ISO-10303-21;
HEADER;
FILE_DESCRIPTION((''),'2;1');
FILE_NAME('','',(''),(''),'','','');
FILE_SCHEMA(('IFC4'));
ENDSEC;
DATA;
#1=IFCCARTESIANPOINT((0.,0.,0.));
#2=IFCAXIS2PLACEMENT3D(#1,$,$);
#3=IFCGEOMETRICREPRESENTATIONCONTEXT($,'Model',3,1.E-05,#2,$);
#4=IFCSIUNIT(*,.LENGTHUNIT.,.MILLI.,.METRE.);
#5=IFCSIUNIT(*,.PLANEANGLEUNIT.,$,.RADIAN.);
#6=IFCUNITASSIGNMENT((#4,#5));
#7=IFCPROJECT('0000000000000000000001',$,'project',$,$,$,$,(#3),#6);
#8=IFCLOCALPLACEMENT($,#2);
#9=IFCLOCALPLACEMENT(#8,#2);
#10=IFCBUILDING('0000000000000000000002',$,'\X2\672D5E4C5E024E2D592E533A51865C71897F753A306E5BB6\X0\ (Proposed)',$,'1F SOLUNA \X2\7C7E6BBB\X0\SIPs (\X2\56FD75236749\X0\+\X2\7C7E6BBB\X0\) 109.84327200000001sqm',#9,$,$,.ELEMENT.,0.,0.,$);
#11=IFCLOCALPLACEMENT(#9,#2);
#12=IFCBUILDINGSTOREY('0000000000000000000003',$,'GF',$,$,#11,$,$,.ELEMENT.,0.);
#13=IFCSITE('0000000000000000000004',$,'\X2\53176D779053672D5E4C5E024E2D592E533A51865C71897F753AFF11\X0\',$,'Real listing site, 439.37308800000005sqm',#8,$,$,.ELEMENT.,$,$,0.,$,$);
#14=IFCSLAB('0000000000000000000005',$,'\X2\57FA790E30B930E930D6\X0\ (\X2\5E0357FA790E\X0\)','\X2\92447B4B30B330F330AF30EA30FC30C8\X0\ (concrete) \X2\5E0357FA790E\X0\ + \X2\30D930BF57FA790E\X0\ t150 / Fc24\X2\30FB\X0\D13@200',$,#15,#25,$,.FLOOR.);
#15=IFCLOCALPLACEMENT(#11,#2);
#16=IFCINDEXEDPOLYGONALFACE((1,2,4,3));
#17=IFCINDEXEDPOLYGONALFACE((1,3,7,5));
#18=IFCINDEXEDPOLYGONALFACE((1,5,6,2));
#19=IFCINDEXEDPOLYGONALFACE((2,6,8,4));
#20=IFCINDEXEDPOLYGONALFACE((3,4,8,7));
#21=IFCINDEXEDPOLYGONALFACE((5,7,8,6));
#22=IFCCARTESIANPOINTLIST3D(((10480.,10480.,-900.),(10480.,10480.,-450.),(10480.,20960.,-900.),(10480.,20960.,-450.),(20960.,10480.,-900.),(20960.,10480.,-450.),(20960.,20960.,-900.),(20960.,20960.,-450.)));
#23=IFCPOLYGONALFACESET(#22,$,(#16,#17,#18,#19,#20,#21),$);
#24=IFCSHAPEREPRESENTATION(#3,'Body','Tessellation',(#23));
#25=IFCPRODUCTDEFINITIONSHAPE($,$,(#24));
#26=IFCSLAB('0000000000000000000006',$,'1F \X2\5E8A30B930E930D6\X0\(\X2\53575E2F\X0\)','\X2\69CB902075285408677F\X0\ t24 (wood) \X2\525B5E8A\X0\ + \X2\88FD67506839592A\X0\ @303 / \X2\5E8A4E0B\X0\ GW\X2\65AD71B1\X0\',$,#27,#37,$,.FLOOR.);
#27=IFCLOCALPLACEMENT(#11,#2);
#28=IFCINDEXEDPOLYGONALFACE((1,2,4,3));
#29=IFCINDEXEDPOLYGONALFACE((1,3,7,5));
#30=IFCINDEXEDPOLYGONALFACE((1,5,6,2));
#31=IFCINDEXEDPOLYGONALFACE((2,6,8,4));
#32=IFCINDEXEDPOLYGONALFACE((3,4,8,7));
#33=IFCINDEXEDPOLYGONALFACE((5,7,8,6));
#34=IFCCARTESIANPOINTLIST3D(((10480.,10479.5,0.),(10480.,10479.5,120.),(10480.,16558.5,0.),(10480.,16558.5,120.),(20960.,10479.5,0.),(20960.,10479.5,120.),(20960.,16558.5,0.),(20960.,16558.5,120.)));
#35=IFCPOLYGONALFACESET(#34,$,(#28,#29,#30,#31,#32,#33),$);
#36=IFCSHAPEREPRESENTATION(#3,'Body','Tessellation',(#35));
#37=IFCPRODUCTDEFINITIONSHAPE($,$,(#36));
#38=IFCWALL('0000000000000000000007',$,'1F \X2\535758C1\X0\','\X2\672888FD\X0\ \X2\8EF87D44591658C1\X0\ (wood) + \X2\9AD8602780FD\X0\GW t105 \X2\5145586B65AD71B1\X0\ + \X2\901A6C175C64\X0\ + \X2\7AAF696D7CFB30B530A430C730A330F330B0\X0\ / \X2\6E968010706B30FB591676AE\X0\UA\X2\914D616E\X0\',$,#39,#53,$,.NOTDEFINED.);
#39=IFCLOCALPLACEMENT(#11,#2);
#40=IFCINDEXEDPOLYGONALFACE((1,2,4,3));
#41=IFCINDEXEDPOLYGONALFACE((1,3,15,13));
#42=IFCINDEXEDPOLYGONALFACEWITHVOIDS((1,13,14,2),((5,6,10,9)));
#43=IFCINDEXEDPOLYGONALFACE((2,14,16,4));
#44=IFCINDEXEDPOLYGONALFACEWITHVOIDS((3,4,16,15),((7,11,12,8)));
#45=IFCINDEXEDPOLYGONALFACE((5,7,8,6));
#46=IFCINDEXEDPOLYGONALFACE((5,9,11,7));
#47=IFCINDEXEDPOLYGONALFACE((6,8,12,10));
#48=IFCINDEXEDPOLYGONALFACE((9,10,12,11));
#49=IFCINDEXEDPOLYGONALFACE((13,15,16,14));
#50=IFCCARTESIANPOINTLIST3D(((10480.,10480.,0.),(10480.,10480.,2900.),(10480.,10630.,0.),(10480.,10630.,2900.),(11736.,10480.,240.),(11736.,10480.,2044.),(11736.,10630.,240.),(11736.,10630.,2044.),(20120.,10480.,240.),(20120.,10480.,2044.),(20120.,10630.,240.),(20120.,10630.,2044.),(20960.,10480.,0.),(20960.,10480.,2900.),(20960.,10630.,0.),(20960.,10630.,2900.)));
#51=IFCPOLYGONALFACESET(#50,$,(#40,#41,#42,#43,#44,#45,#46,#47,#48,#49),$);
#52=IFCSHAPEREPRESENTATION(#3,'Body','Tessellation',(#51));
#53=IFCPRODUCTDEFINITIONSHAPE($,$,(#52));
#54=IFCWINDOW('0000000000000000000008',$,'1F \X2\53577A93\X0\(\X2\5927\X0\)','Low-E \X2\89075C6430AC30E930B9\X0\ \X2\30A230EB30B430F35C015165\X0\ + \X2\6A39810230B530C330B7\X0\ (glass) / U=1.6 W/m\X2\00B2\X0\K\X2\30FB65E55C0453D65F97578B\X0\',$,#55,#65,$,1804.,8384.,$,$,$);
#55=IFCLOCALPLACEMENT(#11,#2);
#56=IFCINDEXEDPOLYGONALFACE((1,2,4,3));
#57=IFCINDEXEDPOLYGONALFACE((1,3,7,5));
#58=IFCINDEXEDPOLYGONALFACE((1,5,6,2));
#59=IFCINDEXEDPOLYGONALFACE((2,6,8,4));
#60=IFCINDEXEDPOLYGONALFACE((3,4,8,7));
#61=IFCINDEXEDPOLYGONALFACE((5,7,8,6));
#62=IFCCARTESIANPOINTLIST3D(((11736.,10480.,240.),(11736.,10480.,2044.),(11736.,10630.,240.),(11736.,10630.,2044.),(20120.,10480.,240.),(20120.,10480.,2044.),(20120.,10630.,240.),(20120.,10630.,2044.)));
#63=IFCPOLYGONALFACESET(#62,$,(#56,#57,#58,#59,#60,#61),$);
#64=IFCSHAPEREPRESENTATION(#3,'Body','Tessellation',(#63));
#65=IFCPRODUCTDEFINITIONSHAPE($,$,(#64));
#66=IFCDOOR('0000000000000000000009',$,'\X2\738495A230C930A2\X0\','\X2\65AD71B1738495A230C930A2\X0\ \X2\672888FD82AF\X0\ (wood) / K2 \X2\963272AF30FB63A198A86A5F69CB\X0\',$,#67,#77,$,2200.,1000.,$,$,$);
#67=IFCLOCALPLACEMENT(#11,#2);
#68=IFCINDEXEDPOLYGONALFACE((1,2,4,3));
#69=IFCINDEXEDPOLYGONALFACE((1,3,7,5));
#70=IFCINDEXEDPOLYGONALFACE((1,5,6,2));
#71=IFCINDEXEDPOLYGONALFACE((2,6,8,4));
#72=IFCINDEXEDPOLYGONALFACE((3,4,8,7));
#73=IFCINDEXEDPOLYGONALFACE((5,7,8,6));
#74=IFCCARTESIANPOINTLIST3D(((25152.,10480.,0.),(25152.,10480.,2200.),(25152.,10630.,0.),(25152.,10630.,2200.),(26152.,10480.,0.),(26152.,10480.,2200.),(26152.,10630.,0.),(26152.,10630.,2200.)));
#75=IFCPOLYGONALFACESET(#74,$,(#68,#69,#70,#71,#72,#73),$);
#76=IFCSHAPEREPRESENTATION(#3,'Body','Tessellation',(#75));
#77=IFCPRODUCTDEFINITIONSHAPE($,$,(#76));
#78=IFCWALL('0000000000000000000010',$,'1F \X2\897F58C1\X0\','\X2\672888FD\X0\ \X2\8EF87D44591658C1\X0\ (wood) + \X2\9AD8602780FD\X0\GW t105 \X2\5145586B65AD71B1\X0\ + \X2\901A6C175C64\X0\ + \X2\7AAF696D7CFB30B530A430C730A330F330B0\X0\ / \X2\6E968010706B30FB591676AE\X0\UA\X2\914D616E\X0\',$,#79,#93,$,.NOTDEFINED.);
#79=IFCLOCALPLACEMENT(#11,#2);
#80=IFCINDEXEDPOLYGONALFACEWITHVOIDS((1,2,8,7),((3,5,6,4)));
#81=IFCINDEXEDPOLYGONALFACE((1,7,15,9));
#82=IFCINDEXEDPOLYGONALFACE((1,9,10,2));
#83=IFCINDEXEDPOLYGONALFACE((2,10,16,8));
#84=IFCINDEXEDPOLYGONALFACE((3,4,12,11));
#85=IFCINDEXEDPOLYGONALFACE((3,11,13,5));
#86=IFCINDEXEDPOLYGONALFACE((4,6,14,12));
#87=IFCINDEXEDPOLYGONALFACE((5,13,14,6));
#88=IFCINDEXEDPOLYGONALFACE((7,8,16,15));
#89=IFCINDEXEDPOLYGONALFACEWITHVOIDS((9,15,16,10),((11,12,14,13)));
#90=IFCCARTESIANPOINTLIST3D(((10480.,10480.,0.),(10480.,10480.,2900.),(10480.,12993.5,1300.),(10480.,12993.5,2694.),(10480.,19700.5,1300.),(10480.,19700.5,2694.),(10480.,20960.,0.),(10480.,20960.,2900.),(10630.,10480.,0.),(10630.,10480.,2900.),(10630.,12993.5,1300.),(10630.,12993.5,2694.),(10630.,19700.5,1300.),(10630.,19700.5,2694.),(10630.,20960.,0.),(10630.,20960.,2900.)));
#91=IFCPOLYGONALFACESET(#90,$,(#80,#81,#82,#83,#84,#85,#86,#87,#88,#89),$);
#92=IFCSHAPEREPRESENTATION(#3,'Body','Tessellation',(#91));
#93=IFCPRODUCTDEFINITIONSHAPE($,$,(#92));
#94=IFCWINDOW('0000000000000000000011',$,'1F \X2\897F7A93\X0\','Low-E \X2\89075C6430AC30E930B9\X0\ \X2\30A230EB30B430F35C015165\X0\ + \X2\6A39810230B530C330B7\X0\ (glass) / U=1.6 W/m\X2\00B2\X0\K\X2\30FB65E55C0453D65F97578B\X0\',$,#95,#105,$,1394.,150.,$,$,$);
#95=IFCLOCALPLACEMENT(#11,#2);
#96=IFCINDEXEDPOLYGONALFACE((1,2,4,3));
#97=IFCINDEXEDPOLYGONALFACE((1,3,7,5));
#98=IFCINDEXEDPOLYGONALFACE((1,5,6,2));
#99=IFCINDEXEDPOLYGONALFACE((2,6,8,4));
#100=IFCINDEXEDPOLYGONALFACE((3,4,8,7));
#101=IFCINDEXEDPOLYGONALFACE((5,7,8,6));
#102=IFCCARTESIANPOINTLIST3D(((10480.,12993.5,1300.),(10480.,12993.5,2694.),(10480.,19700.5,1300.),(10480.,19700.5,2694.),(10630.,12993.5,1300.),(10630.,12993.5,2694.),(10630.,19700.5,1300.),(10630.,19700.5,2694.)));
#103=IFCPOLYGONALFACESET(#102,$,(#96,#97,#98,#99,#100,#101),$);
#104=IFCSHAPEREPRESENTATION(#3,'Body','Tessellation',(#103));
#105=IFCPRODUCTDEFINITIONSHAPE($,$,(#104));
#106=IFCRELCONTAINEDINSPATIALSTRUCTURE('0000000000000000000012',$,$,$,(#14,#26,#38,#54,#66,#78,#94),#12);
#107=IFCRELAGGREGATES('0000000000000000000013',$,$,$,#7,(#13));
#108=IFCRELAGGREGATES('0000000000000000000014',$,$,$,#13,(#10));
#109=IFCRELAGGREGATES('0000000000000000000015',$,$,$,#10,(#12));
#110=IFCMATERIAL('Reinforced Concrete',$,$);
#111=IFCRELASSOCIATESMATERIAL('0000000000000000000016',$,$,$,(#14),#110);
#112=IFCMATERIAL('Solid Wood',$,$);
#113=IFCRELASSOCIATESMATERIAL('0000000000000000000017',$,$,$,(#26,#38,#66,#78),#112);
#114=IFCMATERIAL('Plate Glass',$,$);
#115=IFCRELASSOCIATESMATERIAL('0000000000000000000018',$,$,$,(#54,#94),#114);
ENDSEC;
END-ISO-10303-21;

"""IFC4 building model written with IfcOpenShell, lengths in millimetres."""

from ifc_helpers import new_model, si_unit, frame, frame_2d, origin, place, context, project, spatial, rectangle, extrude, material, element, fill, save


model = new_model("IFC4")

# Units and contexts
model_context = context("Model", 3, precision=1e-05, world=origin())
ifc_project = project(units=[si_unit("LENGTHUNIT", "METRE", prefix="MILLI"), si_unit("PLANEANGLEUNIT", "RADIAN")], contexts=[model_context])

# Site, building, storey
site_placement = place(None, origin())
site = spatial("IfcSite", under=ifc_project, at=site_placement, Name="北海道札幌市中央区円山西町１", ObjectType="Real listing site, 439.37308800000005sqm", CompositionType="ELEMENT", RefElevation=0.0)
building_placement = place(site_placement, origin())
building = spatial("IfcBuilding", under=site, at=building_placement, Name="札幌市中央区円山西町の家 (Proposed)", ObjectType="1F SOLUNA 籾殻SIPs (国産杉+籾殻) 109.84327200000001sqm", CompositionType="ELEMENT", ElevationOfRefHeight=0.0, ElevationOfTerrain=0.0)
storey_placement = place(building_placement, origin())
storey = spatial("IfcBuildingStorey", under=building, at=storey_placement, Name="GF", CompositionType="ELEMENT", Elevation=0.0)

# Slabs
ifc_material_1 = material(Name="Reinforced Concrete")
slab_1_placement = place(storey_placement, frame((5240.0, 5240.0, -450.0)))
element("IfcSlab", 1, at=slab_1_placement, inside=storey, material=ifc_material_1, Name="基礎スラブ (布基礎)", Description="鉄筋コンクリート (concrete) 布基礎 + ベタ基礎 t150 / Fc24・D13@200", PredefinedType="FLOOR", context=model_context, shape_type="SweptSolid", body=[
    extrude(rectangle(XDim=10480.0, YDim=10480.0, at=frame_2d((5240.0, 5240.0))), frame((5240.0, 5240.0, -450.0)), (0.0, 0.0, 1.0), 450.0),
])
ifc_material_2 = material(Name="Solid Wood")
slab_2_placement = place(storey_placement, frame((5240.0, 5240.0, 0.0)))
element("IfcSlab", 2, at=slab_2_placement, inside=storey, material=ifc_material_2, Name="1F 床スラブ(南帯)", Description="構造用合板 t24 (wood) 剛床 + 製材根太 @303 / 床下 GW断熱", PredefinedType="FLOOR", context=model_context, shape_type="SweptSolid", body=[
    extrude(rectangle(XDim=10480.0, YDim=6079.0, at=frame_2d((5240.0, 3039.0))), frame((5240.0, 5240.0, 0.0)), (0.0, 0.0, 1.0), 120.0),
])

# Wall, openings, window, door
wall_1_placement = place(storey_placement, frame((5240.0, 5240.0, 0.0)))
wall_1 = element("IfcWall", 3, at=wall_1_placement, inside=storey, material=ifc_material_2, Name="1F 南壁", Description="木製 軸組外壁 (wood) + 高性能GW t105 充填断熱 + 通気層 + 窯業系サイディング / 準耐火・外皮UA配慮", PredefinedType="NOTDEFINED", context=model_context, shape_type="SweptSolid", body=[
    extrude(rectangle(XDim=10480.0, YDim=150.0, at=frame_2d((5240.0, 75.0))), frame((5240.0, 5240.0, 0.0)), (0.0, 0.0, 1.0), 2900.0),
])
opening_1_placement = place(storey_placement, frame((5868.0, 5240.0, 120.0)))
opening_1 = element("IfcOpeningElement", 4, at=opening_1_placement, cuts=wall_1, PredefinedType="NOTDEFINED", context=model_context, shape_type="SweptSolid", body=[
    extrude(rectangle(XDim=8384.0, YDim=150.0, at=frame_2d((4192.0, 75.0))), frame((5868.0, 5240.0, 120.0)), (0.0, 0.0, 1.0), 1804.0),
])
opening_2_placement = place(storey_placement, frame((12576.0, 5240.0, 0.0)))
opening_2 = element("IfcOpeningElement", 5, at=opening_2_placement, cuts=wall_1, PredefinedType="NOTDEFINED", context=model_context, shape_type="SweptSolid", body=[
    extrude(rectangle(XDim=1000.0, YDim=150.0, at=frame_2d((500.0, 75.0))), frame((12576.0, 5240.0, 0.0)), (0.0, 0.0, 1.0), 2200.0),
])
ifc_material_3 = material(Name="Plate Glass")
window_1_placement = place(storey_placement, frame((5868.0, 5240.0, 120.0)))
window_1 = element("IfcWindow", 6, at=window_1_placement, inside=storey, material=ifc_material_3, Name="1F 南窓(大)", Description="Low-E 複層ガラス アルゴン封入 + 樹脂サッシ (glass) / U=1.6 W/m²K・日射取得型", OverallHeight=1804.0, OverallWidth=8384.0, context=model_context, shape_type="SweptSolid", body=[
    extrude(rectangle(XDim=8384.0, YDim=150.0, at=frame_2d((4192.0, 75.0))), frame((5868.0, 5240.0, 120.0)), (0.0, 0.0, 1.0), 1804.0),
])
fill(opening_1, window_1)
door_1_placement = place(storey_placement, frame((12576.0, 5240.0, 0.0)))
door_1 = element("IfcDoor", 7, at=door_1_placement, inside=storey, material=ifc_material_2, Name="玄関ドア", Description="断熱玄関ドア 木製芯 (wood) / K2 防犯・採風機構", OverallHeight=2200.0, OverallWidth=1000.0, context=model_context, shape_type="SweptSolid", body=[
    extrude(rectangle(XDim=1000.0, YDim=150.0, at=frame_2d((500.0, 75.0))), frame((12576.0, 5240.0, 0.0)), (0.0, 0.0, 1.0), 2200.0),
])
fill(opening_2, door_1)

# Wall, opening, window
wall_2_placement = place(storey_placement, frame((5240.0, 5240.0, 0.0)))
wall_2 = element("IfcWall", 8, at=wall_2_placement, inside=storey, material=ifc_material_2, Name="1F 西壁", Description="木製 軸組外壁 (wood) + 高性能GW t105 充填断熱 + 通気層 + 窯業系サイディング / 準耐火・外皮UA配慮", PredefinedType="NOTDEFINED", context=model_context, shape_type="SweptSolid", body=[
    extrude(rectangle(XDim=150.0, YDim=10480.0, at=frame_2d((75.0, 5240.0))), frame((5240.0, 5240.0, 0.0)), (0.0, 0.0, 1.0), 2900.0),
])
opening_3_placement = place(storey_placement, frame((5240.0, 6497.0, 650.0)))
opening_3 = element("IfcOpeningElement", 9, at=opening_3_placement, cuts=wall_2, PredefinedType="NOTDEFINED", context=model_context, shape_type="SweptSolid", body=[
    extrude(rectangle(XDim=150.0, YDim=6707.0, at=frame_2d((75.0, 3353.0))), frame((5240.0, 6497.0, 650.0)), (0.0, 0.0, 1.0), 1394.0),
])
window_2_placement = place(storey_placement, frame((5240.0, 6497.0, 650.0)))
window_2 = element("IfcWindow", 10, at=window_2_placement, inside=storey, material=ifc_material_3, Name="1F 西窓", Description="Low-E 複層ガラス アルゴン封入 + 樹脂サッシ (glass) / U=1.6 W/m²K・日射取得型", OverallHeight=1394.0, OverallWidth=150.0, context=model_context, shape_type="SweptSolid", body=[
    extrude(rectangle(XDim=150.0, YDim=6707.0, at=frame_2d((75.0, 3353.0))), frame((5240.0, 6497.0, 650.0)), (0.0, 0.0, 1.0), 1394.0),
])
fill(opening_3, window_2)

save(model, "model.ifc")
